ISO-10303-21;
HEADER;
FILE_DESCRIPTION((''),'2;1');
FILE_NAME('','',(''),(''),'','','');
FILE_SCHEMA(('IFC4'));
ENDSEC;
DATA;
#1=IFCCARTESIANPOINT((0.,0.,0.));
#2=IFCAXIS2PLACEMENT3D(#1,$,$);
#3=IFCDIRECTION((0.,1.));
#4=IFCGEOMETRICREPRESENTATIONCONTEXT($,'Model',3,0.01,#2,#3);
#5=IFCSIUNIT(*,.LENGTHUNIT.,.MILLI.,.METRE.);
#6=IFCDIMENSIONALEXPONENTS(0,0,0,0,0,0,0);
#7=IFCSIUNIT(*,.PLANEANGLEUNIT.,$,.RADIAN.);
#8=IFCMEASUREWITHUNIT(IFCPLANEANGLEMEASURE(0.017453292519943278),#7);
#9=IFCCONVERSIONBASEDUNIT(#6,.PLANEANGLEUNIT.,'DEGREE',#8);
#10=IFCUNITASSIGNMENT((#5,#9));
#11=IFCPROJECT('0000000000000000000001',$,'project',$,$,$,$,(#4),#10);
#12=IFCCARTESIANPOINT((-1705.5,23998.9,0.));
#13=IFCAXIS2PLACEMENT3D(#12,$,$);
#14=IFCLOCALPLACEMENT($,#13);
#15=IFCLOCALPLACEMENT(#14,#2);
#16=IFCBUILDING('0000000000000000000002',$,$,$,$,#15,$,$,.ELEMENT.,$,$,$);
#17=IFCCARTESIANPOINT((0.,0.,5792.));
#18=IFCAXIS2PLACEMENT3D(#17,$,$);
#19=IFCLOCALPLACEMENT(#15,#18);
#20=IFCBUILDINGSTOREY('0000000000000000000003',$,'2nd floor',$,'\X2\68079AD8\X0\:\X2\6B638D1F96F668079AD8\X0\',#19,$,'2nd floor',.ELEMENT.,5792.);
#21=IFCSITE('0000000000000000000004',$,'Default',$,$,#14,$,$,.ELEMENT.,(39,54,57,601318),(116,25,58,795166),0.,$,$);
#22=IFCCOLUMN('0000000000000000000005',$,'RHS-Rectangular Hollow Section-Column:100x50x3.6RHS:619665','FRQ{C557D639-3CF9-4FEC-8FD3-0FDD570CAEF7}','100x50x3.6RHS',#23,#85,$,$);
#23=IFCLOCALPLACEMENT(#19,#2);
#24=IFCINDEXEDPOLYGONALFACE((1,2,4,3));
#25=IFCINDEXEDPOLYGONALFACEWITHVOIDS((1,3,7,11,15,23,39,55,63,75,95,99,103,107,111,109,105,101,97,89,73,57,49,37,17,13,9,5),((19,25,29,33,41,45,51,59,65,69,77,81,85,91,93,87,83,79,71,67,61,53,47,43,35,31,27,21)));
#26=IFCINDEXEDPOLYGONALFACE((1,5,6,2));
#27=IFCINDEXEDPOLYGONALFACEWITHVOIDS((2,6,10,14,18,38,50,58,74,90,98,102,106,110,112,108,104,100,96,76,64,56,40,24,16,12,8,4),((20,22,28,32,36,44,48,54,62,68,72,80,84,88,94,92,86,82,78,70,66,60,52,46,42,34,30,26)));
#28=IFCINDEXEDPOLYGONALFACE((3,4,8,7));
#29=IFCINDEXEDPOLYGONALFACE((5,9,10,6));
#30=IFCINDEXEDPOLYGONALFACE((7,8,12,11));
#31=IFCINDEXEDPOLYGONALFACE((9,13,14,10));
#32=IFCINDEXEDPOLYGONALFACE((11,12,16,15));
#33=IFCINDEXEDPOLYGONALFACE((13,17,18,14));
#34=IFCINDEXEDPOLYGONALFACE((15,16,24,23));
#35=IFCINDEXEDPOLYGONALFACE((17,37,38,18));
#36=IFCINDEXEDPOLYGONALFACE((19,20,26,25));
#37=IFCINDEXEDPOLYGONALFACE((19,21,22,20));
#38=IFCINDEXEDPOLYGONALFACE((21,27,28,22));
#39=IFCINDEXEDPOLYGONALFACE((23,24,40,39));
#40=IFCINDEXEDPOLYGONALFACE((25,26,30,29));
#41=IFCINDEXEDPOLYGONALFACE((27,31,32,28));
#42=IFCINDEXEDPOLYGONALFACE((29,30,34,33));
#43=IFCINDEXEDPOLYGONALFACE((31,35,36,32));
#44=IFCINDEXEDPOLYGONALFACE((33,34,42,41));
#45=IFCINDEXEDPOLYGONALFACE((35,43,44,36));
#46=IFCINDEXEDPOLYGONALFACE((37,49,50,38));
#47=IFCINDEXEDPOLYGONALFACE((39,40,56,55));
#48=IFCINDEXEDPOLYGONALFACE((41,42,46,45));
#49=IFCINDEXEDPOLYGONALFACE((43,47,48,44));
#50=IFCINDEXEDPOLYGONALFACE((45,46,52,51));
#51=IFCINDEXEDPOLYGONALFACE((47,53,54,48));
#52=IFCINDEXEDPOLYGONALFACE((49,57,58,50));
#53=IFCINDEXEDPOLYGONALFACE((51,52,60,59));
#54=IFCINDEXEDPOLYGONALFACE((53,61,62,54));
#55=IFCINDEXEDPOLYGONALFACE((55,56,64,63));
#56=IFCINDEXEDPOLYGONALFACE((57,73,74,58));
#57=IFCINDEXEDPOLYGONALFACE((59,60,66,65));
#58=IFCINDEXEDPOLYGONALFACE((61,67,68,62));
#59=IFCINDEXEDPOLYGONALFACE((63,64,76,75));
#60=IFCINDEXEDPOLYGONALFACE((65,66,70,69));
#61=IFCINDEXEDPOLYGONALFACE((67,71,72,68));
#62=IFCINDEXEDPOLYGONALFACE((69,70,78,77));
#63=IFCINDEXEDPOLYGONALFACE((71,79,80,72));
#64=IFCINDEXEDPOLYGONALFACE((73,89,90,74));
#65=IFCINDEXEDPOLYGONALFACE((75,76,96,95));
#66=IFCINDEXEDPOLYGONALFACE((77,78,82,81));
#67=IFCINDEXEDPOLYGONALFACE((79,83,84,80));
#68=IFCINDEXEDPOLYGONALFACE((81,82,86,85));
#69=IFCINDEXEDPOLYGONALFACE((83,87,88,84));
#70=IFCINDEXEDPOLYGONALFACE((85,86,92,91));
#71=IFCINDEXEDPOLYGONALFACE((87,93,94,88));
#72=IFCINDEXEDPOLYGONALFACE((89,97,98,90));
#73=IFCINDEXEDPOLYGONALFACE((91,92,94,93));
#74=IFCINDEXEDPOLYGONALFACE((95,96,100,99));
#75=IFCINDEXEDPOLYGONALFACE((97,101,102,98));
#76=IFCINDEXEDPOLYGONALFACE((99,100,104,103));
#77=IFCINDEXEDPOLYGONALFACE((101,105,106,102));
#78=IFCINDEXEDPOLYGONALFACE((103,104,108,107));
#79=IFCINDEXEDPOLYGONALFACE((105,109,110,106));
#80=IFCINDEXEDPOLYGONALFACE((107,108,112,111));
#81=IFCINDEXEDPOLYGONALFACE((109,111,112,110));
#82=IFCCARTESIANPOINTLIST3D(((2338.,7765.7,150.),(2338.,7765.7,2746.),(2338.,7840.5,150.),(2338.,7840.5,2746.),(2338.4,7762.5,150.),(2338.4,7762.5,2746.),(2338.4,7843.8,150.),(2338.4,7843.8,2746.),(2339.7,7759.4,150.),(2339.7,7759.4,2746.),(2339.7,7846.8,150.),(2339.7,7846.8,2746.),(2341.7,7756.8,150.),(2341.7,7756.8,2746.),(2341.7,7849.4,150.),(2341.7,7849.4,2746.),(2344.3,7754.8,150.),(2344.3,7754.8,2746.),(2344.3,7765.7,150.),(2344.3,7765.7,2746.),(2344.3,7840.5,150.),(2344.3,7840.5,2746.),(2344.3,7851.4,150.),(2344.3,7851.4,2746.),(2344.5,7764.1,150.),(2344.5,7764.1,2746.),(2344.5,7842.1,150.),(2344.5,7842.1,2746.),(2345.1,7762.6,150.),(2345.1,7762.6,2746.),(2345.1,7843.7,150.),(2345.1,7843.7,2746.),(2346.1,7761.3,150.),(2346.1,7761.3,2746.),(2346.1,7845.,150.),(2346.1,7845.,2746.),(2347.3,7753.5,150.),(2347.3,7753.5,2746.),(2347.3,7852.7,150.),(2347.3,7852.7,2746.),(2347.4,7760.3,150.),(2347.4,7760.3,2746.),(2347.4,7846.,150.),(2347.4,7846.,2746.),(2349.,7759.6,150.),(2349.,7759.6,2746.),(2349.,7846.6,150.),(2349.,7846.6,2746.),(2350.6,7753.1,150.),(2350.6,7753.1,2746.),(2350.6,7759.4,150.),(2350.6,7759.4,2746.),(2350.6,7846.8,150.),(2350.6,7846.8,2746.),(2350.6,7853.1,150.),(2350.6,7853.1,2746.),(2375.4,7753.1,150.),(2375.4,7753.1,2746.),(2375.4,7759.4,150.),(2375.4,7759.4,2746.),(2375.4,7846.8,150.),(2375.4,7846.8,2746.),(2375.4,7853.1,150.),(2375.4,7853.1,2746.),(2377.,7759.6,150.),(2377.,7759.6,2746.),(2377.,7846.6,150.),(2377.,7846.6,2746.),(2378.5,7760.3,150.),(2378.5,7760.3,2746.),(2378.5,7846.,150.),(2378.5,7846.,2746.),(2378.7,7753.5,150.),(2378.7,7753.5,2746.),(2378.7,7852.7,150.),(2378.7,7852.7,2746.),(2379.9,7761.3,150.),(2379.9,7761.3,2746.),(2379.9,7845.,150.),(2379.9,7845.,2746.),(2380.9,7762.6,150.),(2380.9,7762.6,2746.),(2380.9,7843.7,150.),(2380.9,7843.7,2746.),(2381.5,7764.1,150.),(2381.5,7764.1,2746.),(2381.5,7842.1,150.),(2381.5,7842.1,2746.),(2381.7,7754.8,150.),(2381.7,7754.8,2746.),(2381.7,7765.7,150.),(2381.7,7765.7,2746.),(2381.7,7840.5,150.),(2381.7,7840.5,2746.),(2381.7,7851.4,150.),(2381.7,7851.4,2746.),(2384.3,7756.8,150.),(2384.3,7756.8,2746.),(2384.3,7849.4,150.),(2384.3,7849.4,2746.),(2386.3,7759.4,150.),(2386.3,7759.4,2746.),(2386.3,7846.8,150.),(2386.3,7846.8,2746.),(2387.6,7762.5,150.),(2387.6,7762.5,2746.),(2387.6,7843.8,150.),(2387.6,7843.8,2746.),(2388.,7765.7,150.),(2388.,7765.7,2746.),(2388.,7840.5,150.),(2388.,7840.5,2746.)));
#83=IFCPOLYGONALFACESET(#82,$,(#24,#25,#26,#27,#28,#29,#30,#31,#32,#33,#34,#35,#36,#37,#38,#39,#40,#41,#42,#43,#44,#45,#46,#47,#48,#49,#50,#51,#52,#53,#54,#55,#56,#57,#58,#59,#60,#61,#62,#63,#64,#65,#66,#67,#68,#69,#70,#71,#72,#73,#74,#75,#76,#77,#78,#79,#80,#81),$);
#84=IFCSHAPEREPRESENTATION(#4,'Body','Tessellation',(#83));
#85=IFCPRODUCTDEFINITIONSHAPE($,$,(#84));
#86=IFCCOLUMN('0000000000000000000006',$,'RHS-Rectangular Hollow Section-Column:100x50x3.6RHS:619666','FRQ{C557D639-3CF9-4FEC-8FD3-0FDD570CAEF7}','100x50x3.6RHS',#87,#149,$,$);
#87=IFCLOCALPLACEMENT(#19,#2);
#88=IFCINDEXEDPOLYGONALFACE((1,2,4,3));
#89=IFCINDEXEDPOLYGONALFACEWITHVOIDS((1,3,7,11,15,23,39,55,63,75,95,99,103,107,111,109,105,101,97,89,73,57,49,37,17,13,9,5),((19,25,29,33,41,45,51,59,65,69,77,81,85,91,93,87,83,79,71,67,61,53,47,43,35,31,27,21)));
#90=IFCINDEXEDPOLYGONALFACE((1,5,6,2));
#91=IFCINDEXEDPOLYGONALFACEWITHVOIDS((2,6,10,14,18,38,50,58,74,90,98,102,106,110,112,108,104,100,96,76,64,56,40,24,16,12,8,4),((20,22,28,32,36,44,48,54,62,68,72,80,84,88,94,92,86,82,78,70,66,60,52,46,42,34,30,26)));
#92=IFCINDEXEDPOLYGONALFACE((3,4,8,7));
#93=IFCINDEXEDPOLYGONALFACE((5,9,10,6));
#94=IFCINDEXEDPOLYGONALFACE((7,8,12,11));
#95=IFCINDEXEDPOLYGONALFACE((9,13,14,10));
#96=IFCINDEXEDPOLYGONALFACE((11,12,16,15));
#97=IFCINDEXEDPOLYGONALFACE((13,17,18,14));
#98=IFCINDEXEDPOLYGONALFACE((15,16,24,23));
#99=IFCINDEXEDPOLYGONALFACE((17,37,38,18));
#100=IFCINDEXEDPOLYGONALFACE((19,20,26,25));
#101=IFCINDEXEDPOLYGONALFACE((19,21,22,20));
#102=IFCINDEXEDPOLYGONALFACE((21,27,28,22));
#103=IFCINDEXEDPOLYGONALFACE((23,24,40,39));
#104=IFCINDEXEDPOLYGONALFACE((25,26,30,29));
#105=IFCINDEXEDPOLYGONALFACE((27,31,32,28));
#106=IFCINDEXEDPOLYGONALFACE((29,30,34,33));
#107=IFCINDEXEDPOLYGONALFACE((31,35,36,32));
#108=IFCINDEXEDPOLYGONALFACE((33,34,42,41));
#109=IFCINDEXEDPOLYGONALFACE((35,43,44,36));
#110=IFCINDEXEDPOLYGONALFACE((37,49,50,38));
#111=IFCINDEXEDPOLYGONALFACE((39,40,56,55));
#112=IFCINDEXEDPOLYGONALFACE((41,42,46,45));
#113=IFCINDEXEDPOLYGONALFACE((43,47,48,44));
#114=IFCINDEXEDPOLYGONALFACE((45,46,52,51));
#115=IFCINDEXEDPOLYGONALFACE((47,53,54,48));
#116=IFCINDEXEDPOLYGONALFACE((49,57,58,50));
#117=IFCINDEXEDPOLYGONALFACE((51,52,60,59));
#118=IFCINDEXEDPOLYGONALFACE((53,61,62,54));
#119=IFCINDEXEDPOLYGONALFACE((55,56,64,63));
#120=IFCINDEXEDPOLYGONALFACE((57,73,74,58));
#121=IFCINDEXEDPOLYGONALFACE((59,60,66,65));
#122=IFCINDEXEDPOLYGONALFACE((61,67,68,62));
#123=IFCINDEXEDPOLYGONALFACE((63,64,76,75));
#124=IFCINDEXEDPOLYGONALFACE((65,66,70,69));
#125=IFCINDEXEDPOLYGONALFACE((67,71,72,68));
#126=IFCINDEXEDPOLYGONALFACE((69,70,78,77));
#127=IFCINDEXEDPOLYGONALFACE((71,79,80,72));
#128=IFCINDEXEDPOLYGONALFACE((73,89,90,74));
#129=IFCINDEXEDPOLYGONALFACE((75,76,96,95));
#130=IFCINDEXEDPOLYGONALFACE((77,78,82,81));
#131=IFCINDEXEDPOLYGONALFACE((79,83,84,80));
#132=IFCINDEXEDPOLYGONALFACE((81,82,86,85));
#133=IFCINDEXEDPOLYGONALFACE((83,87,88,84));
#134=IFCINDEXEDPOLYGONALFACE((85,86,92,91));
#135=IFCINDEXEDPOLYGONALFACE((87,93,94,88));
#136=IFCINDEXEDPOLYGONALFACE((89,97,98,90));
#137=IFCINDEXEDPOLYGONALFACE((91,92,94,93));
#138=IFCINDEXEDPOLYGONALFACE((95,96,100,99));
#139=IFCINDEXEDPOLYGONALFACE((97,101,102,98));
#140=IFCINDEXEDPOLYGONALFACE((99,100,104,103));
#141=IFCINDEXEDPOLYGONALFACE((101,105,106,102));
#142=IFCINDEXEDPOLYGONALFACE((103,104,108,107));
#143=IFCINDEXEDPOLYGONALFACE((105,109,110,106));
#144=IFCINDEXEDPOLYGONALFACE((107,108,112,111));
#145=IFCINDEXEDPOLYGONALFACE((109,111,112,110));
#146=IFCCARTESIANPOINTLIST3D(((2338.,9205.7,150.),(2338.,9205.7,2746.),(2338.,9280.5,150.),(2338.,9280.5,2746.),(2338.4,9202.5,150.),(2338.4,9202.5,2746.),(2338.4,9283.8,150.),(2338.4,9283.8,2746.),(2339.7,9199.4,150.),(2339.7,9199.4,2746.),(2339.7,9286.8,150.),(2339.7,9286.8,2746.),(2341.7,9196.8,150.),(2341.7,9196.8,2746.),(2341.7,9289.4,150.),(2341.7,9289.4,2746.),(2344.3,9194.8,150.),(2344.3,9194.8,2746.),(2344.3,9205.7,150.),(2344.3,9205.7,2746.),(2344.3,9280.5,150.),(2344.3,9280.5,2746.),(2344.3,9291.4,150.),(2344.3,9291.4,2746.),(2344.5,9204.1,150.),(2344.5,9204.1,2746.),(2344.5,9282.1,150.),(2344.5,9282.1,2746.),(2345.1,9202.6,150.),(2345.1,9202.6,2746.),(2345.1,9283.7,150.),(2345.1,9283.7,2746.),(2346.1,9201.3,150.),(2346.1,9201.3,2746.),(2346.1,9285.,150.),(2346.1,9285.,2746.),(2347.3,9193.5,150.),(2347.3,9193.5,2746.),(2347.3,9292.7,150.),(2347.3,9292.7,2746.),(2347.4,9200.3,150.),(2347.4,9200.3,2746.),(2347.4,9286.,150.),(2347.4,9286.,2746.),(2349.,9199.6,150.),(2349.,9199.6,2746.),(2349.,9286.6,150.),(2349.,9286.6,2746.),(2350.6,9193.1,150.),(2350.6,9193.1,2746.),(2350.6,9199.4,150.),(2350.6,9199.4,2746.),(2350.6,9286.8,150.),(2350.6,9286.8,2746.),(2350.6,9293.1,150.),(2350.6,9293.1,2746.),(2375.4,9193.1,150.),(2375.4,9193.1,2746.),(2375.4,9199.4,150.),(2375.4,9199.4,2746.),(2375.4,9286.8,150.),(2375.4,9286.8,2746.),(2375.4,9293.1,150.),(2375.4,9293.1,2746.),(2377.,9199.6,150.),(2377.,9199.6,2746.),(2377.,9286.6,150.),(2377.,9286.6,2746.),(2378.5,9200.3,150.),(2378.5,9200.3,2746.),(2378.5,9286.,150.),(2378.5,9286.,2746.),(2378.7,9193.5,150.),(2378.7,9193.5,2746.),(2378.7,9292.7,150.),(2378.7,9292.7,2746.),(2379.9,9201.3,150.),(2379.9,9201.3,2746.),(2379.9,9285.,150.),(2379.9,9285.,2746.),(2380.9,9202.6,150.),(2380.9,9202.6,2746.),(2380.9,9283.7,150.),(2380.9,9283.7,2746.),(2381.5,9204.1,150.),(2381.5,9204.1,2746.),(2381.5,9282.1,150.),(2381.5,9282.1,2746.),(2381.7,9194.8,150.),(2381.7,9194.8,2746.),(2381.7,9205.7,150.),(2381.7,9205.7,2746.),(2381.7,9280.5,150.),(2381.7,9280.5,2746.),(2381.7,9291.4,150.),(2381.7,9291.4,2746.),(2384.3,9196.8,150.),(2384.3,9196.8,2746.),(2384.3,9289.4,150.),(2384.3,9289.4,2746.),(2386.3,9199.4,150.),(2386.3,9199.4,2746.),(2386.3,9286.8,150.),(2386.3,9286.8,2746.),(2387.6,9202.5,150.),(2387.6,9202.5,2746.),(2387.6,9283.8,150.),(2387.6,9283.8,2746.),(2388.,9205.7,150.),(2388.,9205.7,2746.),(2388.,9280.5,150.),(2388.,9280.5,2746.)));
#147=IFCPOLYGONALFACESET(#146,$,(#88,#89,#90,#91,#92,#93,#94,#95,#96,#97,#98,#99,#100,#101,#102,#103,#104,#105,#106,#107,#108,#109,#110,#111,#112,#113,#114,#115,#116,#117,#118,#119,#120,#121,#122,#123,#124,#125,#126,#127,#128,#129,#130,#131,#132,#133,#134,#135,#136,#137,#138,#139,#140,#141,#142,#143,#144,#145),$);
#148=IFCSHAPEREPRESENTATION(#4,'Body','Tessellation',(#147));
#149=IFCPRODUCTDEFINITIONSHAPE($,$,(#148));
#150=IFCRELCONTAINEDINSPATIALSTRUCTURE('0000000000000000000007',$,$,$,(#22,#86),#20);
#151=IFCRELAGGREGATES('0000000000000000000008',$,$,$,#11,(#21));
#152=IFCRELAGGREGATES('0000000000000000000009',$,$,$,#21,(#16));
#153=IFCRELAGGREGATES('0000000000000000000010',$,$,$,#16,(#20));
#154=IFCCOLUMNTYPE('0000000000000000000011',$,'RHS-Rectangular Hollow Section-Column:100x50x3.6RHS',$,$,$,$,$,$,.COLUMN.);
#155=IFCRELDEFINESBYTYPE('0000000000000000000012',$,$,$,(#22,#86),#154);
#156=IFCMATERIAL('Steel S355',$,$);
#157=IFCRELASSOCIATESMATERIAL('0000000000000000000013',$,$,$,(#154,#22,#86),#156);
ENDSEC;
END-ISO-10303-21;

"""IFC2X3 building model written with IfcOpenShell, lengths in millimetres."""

from ifc_helpers import new_model, entity, si_unit, converted_unit, direction, frame, origin, origin_2d, place, context, project, spatial, hollow_rectangle, extrude, clip, halfspace, material, type_object, element, save


model = new_model("IFC2X3")

# Units and contexts
model_context = context("Model", 3, precision=0.01, world=origin(), true_north=direction((0.0, 1.0)))
ifc_project = project(units=[si_unit("LENGTHUNIT", "METRE", prefix="MILLI"), converted_unit("PLANEANGLEUNIT", "DEGREE", entity("IfcPlaneAngleMeasure", 0.017453292519943278), si_unit("PLANEANGLEUNIT", "RADIAN"), dimensions=[0, 0, 0, 0, 0, 0, 0])], contexts=[model_context])

# Site, building, storey
site_placement = place(None, frame((-1705.5, 23998.9, 0.0)))
site = spatial("IfcSite", under=ifc_project, at=site_placement, Name="Default", CompositionType="ELEMENT", RefLatitude=(39, 54, 57, 601318), RefLongitude=(116, 25, 58, 795166), RefElevation=0.0)
building_placement = place(site_placement, origin())
building = spatial("IfcBuilding", under=site, at=building_placement, CompositionType="ELEMENT")
storey_placement = place(building_placement, frame((0.0, 0.0, 5792.0)))
storey = spatial("IfcBuildingStorey", under=building, at=storey_placement, Name="2nd floor", ObjectType="标高:正负零标高", LongName="2nd floor", CompositionType="ELEMENT", Elevation=5792.0)

# Columns
ifc_material_1 = material(Name="Steel S355")
column_type = type_object("IfcColumnType", Name="RHS-Rectangular Hollow Section-Column:100x50x3.6RHS", PredefinedType="COLUMN", material=ifc_material_1)
column_1_placement = place(storey_placement, frame((2363.0, 7803.1, 2746.0), z_axis=(0.0, 0.0, 1.0), x_axis=(-1.0, 0.0, 0.0)))
element("IfcColumn", 1, at=column_1_placement, inside=storey, type_object=column_type, material=ifc_material_1, Name="RHS-Rectangular Hollow Section-Column:100x50x3.6RHS:619665", Description="FRQ{C557D639-3CF9-4FEC-8FD3-0FDD570CAEF7}", ObjectType="100x50x3.6RHS", context=model_context, shape_type="Clipping", body=[
    clip(extrude(hollow_rectangle(XDim=50.0, YDim=100.0, WallThickness=6.3, InnerFilletRadius=6.3, OuterFilletRadius=12.6, at=origin_2d()), origin(), (0.0, 0.0, -1.0), 2651.9), halfspace(frame((2363.0, 7803.1, -2596.0), z_axis=(0.0, 0.0, 1.0), x_axis=(-1.0, 0.0, 0.0)), True)),
])
column_2_placement = place(storey_placement, frame((2363.0, 9243.1, 2746.0), z_axis=(0.0, 0.0, 1.0), x_axis=(-1.0, 0.0, 0.0)))
element("IfcColumn", 2, at=column_2_placement, inside=storey, type_object=column_type, material=ifc_material_1, Name="RHS-Rectangular Hollow Section-Column:100x50x3.6RHS:619666", Description="FRQ{C557D639-3CF9-4FEC-8FD3-0FDD570CAEF7}", ObjectType="100x50x3.6RHS", context=model_context, shape_type="Clipping", body=[
    clip(extrude(hollow_rectangle(XDim=50.0, YDim=100.0, WallThickness=6.3, InnerFilletRadius=6.3, OuterFilletRadius=12.6, at=origin_2d()), origin(), (0.0, 0.0, -1.0), 2651.9), halfspace(frame((2363.0, 9243.1, -2596.0), z_axis=(0.0, 0.0, 1.0), x_axis=(-1.0, 0.0, 0.0)), True)),
])

save(model, "model.ifc")
